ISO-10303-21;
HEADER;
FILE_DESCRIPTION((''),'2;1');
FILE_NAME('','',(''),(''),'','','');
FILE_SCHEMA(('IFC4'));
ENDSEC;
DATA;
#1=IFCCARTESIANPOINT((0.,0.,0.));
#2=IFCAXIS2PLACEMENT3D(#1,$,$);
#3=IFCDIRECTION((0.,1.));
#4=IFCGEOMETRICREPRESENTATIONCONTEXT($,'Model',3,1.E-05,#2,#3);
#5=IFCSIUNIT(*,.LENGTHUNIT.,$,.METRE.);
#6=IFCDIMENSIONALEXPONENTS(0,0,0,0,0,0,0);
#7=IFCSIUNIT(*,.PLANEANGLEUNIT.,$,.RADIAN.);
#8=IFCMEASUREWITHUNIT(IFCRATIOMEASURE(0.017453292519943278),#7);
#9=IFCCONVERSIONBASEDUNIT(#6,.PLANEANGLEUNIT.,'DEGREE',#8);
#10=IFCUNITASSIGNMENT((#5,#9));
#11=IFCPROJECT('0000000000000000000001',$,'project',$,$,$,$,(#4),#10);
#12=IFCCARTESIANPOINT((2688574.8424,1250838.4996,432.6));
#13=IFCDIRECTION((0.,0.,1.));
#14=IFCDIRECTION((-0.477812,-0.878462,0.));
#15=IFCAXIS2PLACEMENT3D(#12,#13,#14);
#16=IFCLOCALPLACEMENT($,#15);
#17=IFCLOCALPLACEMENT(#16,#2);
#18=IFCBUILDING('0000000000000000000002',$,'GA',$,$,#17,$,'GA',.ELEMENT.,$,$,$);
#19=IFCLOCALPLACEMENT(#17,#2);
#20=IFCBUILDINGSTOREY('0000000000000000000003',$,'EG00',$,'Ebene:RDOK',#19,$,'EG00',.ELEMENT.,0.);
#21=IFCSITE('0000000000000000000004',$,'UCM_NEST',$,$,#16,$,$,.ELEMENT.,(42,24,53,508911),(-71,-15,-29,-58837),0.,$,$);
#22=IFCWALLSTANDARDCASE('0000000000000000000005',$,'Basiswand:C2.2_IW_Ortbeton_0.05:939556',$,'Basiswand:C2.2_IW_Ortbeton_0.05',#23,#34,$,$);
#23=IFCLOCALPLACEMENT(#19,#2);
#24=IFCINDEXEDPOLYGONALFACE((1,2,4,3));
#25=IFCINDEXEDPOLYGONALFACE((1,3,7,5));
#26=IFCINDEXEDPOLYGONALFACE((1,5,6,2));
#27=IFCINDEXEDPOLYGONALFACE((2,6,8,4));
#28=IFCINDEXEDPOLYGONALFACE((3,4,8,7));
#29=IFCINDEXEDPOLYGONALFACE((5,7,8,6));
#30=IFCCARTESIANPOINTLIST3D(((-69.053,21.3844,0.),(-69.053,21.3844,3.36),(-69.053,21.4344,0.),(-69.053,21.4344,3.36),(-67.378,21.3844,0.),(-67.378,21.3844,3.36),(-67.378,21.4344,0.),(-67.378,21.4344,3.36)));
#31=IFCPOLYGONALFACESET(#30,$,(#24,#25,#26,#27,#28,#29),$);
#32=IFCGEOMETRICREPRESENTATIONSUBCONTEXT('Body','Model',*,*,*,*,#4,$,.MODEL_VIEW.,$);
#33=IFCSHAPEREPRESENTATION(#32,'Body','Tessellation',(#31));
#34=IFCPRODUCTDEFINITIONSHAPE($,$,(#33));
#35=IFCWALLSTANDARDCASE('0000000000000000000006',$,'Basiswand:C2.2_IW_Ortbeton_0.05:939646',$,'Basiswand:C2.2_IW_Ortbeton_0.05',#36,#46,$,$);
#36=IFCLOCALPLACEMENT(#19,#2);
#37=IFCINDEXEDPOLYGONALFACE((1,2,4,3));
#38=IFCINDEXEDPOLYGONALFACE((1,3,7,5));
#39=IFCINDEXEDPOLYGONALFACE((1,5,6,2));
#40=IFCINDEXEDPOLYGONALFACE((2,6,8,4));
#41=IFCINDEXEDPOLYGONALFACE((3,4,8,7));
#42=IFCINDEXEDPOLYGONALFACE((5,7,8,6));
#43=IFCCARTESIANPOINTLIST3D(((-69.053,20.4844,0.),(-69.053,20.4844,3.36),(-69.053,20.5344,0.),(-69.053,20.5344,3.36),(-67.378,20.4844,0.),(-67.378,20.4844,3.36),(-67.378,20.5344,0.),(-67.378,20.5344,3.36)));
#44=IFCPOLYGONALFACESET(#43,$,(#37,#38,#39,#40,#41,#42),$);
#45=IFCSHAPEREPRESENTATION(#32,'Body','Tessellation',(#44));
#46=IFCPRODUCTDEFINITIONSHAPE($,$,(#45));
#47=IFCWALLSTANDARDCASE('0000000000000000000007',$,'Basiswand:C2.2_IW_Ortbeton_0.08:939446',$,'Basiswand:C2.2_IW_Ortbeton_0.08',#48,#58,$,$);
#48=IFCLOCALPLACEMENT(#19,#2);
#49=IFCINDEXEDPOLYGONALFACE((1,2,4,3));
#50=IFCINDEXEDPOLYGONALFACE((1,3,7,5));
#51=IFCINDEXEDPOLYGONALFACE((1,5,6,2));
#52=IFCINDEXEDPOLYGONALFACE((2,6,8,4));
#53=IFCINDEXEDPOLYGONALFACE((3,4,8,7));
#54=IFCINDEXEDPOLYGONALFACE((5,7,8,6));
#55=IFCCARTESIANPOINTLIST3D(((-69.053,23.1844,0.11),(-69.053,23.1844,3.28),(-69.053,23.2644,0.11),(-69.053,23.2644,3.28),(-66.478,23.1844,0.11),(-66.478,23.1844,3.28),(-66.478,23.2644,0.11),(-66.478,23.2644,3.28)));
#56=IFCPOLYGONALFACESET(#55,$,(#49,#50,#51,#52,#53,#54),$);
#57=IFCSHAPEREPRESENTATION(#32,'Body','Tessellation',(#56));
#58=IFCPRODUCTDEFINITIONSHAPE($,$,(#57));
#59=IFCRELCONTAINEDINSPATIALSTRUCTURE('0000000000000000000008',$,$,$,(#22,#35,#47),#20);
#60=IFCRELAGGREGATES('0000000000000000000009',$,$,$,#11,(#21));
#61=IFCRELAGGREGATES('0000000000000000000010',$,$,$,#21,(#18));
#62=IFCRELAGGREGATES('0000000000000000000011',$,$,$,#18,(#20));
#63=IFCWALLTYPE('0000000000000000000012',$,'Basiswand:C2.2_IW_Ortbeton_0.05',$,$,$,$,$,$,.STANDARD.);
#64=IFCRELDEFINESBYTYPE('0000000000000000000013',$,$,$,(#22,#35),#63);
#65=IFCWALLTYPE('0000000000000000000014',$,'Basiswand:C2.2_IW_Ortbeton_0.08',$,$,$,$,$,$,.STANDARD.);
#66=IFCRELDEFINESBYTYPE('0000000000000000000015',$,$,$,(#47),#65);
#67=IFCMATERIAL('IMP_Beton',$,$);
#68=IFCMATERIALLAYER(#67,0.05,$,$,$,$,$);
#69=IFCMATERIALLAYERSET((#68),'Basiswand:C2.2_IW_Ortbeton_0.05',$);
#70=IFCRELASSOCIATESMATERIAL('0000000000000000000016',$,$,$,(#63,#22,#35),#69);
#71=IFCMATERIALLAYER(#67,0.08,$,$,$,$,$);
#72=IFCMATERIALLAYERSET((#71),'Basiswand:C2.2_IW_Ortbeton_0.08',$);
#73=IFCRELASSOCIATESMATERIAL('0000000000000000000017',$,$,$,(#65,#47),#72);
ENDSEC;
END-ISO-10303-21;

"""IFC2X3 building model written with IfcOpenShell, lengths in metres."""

from ifc_helpers import new_model, entity, si_unit, converted_unit, direction, frame, frame_2d, origin, place, context, subcontext, project, spatial, polyline, rectangle, extrude, clip, bounded_halfspace, material, layer, layer_set, layer_usage, type_object, element, save


model = new_model("IFC2X3")

# Units and contexts
model_context = context("Model", 3, precision=1e-05, world=origin(), true_north=direction((0.0, 1.0)))
body_context = subcontext(model_context, "Body", "Model", "MODEL_VIEW")
ifc_project = project(units=[si_unit("LENGTHUNIT", "METRE"), converted_unit("PLANEANGLEUNIT", "DEGREE", entity("IfcRatioMeasure", 0.017453292519943278), si_unit("PLANEANGLEUNIT", "RADIAN"), dimensions=[0, 0, 0, 0, 0, 0, 0])], contexts=[model_context])

# Site, building, storey
site_placement = place(None, frame((2688574.8424, 1250838.4996, 432.6), z_axis=(0.0, 0.0, 1.0), x_axis=(-0.477812, -0.878462, 0.0)))
site = spatial("IfcSite", under=ifc_project, at=site_placement, Name="UCM_NEST", CompositionType="ELEMENT", RefLatitude=(42, 24, 53, 508911), RefLongitude=(-71, -15, -29, -58837), RefElevation=0.0)
building_placement = place(site_placement, origin())
building = spatial("IfcBuilding", under=site, at=building_placement, Name="GA", LongName="GA", CompositionType="ELEMENT")
storey_placement = place(building_placement, origin())
storey = spatial("IfcBuildingStorey", under=building, at=storey_placement, Name="EG00", ObjectType="Ebene:RDOK", LongName="EG00", CompositionType="ELEMENT", Elevation=0.0)

# Shared definitions
ifc_material_1 = material(Name="IMP_Beton")

# Walls
ifc_layer_1 = layer(ifc_material_1, 0.05)
ifc_layer_set_1 = layer_set([ifc_layer_1], Name="Basiswand:C2.2_IW_Ortbeton_0.05")
ifc_layer_usage_1 = layer_usage(ifc_layer_set_1, "AXIS2", "NEGATIVE", 0.025)
wall_type_1 = type_object("IfcWallType", Name="Basiswand:C2.2_IW_Ortbeton_0.05", PredefinedType="STANDARD", material=ifc_layer_set_1)
for number, where, name in (
    (1, (-69.053, 21.4094, 0.0), "Basiswand:C2.2_IW_Ortbeton_0.05:939556"),
    (2, (-69.053, 20.5094, 0.0), "Basiswand:C2.2_IW_Ortbeton_0.05:939646"),
):
    element("IfcWallStandardCase", number, at=place(storey_placement, frame(where)), inside=storey, type_object=wall_type_1, material=ifc_layer_usage_1, Name=name, ObjectType="Basiswand:C2.2_IW_Ortbeton_0.05", context=body_context, shape_type="SweptSolid", body=[
        extrude(rectangle(XDim=1.675, YDim=0.05, at=frame_2d((0.8375, 0.0), x_axis=(-1.0, 0.0))), origin(), (0.0, 0.0, 1.0), 3.36),
    ])
ifc_layer_2 = layer(ifc_material_1, 0.08)
ifc_layer_set_2 = layer_set([ifc_layer_2], Name="Basiswand:C2.2_IW_Ortbeton_0.08")
ifc_layer_usage_2 = layer_usage(ifc_layer_set_2, "AXIS2", "NEGATIVE", 0.04)
wall_type_2 = type_object("IfcWallType", Name="Basiswand:C2.2_IW_Ortbeton_0.08", PredefinedType="STANDARD", material=ifc_layer_set_2)
wall_1_placement = place(storey_placement, frame((-69.053, 23.2244, 0.11)))
element("IfcWallStandardCase", 3, at=wall_1_placement, inside=storey, type_object=wall_type_2, material=ifc_layer_usage_2, Name="Basiswand:C2.2_IW_Ortbeton_0.08:939446", ObjectType="Basiswand:C2.2_IW_Ortbeton_0.08", context=body_context, shape_type="Clipping", body=[
    clip(clip(extrude(rectangle(XDim=2.575, YDim=0.08, at=frame_2d((1.2875, 0.0), x_axis=(-1.0, 0.0))), origin(), (0.0, 0.0, 1.0), 3.17), bounded_halfspace(frame((0.0, -0.04, 3.17), z_axis=(0.0, 0.0, -1.0), x_axis=(-1.0, 0.0, 0.0)), True, frame((0.0, -0.04, 3.17), z_axis=(0.0, 0.0, -1.0), x_axis=(-1.0, 0.0, 0.0)), polyline([(0.0, 0.0), (0.0, 0.08), (-2.575, 0.08), (-2.575, 0.0), (0.0, 0.0)]))), bounded_halfspace(frame((2.575, -0.04, 0.0), z_axis=(0.0, 0.0, 1.0), x_axis=(-1.0, 0.0, 0.0)), True, frame((2.575, -0.04, 0.0), z_axis=(0.0, 0.0, 1.0), x_axis=(-1.0, 0.0, 0.0)), polyline([(0.0, 0.0), (0.0, -0.08), (2.575, -0.08), (2.575, 0.0), (0.0, 0.0)]))),
])

save(model, "model.ifc")
